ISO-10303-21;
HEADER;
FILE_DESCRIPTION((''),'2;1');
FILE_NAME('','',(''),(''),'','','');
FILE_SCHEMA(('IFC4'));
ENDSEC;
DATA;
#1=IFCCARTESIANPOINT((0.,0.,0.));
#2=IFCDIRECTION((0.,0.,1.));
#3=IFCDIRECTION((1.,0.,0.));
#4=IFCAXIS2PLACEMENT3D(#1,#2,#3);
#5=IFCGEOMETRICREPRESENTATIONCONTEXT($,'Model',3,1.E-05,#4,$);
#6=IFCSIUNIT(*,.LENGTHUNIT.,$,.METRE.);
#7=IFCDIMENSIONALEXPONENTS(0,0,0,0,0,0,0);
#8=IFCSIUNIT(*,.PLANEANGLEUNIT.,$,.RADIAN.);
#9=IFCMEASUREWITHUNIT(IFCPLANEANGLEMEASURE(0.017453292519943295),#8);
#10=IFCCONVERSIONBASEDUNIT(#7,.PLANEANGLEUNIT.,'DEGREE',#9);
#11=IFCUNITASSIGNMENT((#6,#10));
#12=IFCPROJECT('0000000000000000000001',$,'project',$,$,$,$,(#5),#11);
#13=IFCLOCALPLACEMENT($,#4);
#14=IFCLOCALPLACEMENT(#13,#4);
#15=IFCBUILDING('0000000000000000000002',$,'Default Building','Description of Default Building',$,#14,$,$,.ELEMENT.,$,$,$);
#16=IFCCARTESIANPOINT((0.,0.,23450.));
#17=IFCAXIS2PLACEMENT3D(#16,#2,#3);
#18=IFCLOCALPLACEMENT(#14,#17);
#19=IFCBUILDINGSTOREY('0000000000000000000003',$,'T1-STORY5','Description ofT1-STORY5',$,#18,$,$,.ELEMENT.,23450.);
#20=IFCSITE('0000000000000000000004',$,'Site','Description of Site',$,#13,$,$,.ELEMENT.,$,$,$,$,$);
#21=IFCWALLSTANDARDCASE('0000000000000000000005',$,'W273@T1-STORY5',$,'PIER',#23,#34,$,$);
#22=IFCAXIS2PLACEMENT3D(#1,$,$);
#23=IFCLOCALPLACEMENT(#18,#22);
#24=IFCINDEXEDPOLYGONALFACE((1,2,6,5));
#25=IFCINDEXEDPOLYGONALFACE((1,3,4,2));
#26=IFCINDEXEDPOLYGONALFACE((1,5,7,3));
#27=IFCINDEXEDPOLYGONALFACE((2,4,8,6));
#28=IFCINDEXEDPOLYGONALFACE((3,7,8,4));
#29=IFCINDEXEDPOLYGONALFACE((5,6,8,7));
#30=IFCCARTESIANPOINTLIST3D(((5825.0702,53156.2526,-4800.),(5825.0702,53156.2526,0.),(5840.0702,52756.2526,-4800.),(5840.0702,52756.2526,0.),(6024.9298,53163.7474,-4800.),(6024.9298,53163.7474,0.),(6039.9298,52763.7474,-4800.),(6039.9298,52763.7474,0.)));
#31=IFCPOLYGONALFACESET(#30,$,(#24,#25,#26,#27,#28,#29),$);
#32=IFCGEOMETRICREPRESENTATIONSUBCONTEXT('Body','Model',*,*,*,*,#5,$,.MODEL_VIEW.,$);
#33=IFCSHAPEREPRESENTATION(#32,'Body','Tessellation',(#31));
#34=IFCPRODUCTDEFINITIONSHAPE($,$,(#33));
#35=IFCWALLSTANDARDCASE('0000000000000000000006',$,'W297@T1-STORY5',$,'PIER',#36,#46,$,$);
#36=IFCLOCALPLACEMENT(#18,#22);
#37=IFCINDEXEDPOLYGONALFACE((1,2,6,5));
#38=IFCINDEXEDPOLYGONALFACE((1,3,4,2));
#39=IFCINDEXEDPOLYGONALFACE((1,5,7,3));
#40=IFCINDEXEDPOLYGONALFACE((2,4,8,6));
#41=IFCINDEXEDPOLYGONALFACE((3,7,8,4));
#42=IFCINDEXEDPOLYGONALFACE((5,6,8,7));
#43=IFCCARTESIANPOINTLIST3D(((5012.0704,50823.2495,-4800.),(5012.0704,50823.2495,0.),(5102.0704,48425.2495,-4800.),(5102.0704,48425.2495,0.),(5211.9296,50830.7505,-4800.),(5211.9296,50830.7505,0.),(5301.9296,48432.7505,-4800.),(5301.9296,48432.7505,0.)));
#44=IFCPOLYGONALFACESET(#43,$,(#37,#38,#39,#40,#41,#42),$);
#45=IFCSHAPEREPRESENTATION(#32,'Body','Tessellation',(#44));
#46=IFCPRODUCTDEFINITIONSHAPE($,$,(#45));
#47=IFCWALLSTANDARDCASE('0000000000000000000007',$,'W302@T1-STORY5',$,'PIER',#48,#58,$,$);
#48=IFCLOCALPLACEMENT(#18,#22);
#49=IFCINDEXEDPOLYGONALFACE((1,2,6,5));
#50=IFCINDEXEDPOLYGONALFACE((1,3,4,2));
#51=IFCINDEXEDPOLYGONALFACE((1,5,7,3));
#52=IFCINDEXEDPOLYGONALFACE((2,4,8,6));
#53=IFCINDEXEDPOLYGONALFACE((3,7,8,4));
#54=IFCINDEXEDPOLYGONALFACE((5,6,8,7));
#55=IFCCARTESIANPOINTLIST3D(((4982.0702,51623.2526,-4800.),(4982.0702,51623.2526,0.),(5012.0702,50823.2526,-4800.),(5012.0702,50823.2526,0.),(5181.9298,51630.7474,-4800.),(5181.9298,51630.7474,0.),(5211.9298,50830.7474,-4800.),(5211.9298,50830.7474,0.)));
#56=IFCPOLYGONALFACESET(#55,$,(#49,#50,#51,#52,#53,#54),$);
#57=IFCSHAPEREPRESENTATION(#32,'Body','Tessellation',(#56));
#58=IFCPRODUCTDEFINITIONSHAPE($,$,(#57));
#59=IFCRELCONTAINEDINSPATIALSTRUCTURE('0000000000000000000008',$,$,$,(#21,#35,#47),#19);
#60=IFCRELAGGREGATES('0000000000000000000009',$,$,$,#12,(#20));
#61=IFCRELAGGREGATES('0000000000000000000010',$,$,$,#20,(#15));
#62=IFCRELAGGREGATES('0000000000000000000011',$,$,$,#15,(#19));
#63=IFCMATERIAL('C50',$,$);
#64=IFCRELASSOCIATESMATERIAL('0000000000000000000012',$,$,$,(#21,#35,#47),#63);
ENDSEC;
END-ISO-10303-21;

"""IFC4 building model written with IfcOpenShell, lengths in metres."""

from ifc_helpers import new_model, entity, si_unit, converted_unit, frame, origin_with_axes, place, context, subcontext, project, spatial, indexed_curve, outline, extrude, material, element, save


model = new_model("IFC4")

# Units and contexts
model_context = context("Model", 3, precision=1e-05, world=origin_with_axes())
body_context = subcontext(model_context, "Body", "Model", "MODEL_VIEW")
ifc_project = project(units=[si_unit("LENGTHUNIT", "METRE"), converted_unit("PLANEANGLEUNIT", "DEGREE", entity("IfcPlaneAngleMeasure", 0.017453292519943295), si_unit("PLANEANGLEUNIT", "RADIAN"), dimensions=[0, 0, 0, 0, 0, 0, 0])], contexts=[model_context])

# Site, building, storey
site_placement = place(None, origin_with_axes())
site = spatial("IfcSite", under=ifc_project, at=site_placement, Name="Site", Description="Description of Site", CompositionType="ELEMENT")
building_placement = place(site_placement, origin_with_axes())
building = spatial("IfcBuilding", under=site, at=building_placement, Name="Default Building", Description="Description of Default Building", CompositionType="ELEMENT")
storey_placement = place(building_placement, frame((0.0, 0.0, 23450.0), z_axis=(0.0, 0.0, 1.0), x_axis=(1.0, 0.0, 0.0)))
storey = spatial("IfcBuildingStorey", under=building, at=storey_placement, Name="T1-STORY5", Description="Description ofT1-STORY5", CompositionType="ELEMENT", Elevation=23450.0)

# Shared definitions
ifc_material_1 = material(Name="C50")

# Walls
wall_1_placement = place(storey_placement, frame((5925.0, 53160.0, -4800.0), z_axis=(0.0, 0.0, 1.0), x_axis=(0.037474, -0.999298, 0.0)))
element("IfcWallStandardCase", 1, at=wall_1_placement, inside=storey, material=ifc_material_1, Name="W273@T1-STORY5", ObjectType="PIER", context=body_context, shape_type="SweptSolid", body=[
    extrude(outline(indexed_curve([(0.0, -100.0), (0.0, 100.0), (400.2812, 100.0), (400.2812, -100.0), (0.0, -100.0)], self_intersect=False)), origin_with_axes(), (0.0, 0.0, 1.0), 4800.0),
])
wall_2_placement = place(storey_placement, frame((5112.0, 50827.0, -4800.0), z_axis=(0.0, 0.0, 1.0), x_axis=(0.037505, -0.999296, 0.0)))
element("IfcWallStandardCase", 2, at=wall_2_placement, inside=storey, material=ifc_material_1, Name="W297@T1-STORY5", ObjectType="PIER", context=body_context, shape_type="SweptSolid", body=[
    extrude(outline(indexed_curve([(0.0, -100.0), (0.0, 100.0), (2399.6883, 100.0), (2399.6883, -100.0), (0.0, -100.0)], self_intersect=False)), origin_with_axes(), (0.0, 0.0, 1.0), 4800.0),
])
wall_3_placement = place(storey_placement, frame((5082.0, 51627.0, -4800.0), z_axis=(0.0, 0.0, 1.0), x_axis=(0.037474, -0.999298, 0.0)))
element("IfcWallStandardCase", 3, at=wall_3_placement, inside=storey, material=ifc_material_1, Name="W302@T1-STORY5", ObjectType="PIER", context=body_context, shape_type="SweptSolid", body=[
    extrude(outline(indexed_curve([(0.0, -100.0), (0.0, 100.0), (800.5623, 100.0), (800.5623, -100.0), (0.0, -100.0)], self_intersect=False)), origin_with_axes(), (0.0, 0.0, 1.0), 4800.0),
])

save(model, "model.ifc")
